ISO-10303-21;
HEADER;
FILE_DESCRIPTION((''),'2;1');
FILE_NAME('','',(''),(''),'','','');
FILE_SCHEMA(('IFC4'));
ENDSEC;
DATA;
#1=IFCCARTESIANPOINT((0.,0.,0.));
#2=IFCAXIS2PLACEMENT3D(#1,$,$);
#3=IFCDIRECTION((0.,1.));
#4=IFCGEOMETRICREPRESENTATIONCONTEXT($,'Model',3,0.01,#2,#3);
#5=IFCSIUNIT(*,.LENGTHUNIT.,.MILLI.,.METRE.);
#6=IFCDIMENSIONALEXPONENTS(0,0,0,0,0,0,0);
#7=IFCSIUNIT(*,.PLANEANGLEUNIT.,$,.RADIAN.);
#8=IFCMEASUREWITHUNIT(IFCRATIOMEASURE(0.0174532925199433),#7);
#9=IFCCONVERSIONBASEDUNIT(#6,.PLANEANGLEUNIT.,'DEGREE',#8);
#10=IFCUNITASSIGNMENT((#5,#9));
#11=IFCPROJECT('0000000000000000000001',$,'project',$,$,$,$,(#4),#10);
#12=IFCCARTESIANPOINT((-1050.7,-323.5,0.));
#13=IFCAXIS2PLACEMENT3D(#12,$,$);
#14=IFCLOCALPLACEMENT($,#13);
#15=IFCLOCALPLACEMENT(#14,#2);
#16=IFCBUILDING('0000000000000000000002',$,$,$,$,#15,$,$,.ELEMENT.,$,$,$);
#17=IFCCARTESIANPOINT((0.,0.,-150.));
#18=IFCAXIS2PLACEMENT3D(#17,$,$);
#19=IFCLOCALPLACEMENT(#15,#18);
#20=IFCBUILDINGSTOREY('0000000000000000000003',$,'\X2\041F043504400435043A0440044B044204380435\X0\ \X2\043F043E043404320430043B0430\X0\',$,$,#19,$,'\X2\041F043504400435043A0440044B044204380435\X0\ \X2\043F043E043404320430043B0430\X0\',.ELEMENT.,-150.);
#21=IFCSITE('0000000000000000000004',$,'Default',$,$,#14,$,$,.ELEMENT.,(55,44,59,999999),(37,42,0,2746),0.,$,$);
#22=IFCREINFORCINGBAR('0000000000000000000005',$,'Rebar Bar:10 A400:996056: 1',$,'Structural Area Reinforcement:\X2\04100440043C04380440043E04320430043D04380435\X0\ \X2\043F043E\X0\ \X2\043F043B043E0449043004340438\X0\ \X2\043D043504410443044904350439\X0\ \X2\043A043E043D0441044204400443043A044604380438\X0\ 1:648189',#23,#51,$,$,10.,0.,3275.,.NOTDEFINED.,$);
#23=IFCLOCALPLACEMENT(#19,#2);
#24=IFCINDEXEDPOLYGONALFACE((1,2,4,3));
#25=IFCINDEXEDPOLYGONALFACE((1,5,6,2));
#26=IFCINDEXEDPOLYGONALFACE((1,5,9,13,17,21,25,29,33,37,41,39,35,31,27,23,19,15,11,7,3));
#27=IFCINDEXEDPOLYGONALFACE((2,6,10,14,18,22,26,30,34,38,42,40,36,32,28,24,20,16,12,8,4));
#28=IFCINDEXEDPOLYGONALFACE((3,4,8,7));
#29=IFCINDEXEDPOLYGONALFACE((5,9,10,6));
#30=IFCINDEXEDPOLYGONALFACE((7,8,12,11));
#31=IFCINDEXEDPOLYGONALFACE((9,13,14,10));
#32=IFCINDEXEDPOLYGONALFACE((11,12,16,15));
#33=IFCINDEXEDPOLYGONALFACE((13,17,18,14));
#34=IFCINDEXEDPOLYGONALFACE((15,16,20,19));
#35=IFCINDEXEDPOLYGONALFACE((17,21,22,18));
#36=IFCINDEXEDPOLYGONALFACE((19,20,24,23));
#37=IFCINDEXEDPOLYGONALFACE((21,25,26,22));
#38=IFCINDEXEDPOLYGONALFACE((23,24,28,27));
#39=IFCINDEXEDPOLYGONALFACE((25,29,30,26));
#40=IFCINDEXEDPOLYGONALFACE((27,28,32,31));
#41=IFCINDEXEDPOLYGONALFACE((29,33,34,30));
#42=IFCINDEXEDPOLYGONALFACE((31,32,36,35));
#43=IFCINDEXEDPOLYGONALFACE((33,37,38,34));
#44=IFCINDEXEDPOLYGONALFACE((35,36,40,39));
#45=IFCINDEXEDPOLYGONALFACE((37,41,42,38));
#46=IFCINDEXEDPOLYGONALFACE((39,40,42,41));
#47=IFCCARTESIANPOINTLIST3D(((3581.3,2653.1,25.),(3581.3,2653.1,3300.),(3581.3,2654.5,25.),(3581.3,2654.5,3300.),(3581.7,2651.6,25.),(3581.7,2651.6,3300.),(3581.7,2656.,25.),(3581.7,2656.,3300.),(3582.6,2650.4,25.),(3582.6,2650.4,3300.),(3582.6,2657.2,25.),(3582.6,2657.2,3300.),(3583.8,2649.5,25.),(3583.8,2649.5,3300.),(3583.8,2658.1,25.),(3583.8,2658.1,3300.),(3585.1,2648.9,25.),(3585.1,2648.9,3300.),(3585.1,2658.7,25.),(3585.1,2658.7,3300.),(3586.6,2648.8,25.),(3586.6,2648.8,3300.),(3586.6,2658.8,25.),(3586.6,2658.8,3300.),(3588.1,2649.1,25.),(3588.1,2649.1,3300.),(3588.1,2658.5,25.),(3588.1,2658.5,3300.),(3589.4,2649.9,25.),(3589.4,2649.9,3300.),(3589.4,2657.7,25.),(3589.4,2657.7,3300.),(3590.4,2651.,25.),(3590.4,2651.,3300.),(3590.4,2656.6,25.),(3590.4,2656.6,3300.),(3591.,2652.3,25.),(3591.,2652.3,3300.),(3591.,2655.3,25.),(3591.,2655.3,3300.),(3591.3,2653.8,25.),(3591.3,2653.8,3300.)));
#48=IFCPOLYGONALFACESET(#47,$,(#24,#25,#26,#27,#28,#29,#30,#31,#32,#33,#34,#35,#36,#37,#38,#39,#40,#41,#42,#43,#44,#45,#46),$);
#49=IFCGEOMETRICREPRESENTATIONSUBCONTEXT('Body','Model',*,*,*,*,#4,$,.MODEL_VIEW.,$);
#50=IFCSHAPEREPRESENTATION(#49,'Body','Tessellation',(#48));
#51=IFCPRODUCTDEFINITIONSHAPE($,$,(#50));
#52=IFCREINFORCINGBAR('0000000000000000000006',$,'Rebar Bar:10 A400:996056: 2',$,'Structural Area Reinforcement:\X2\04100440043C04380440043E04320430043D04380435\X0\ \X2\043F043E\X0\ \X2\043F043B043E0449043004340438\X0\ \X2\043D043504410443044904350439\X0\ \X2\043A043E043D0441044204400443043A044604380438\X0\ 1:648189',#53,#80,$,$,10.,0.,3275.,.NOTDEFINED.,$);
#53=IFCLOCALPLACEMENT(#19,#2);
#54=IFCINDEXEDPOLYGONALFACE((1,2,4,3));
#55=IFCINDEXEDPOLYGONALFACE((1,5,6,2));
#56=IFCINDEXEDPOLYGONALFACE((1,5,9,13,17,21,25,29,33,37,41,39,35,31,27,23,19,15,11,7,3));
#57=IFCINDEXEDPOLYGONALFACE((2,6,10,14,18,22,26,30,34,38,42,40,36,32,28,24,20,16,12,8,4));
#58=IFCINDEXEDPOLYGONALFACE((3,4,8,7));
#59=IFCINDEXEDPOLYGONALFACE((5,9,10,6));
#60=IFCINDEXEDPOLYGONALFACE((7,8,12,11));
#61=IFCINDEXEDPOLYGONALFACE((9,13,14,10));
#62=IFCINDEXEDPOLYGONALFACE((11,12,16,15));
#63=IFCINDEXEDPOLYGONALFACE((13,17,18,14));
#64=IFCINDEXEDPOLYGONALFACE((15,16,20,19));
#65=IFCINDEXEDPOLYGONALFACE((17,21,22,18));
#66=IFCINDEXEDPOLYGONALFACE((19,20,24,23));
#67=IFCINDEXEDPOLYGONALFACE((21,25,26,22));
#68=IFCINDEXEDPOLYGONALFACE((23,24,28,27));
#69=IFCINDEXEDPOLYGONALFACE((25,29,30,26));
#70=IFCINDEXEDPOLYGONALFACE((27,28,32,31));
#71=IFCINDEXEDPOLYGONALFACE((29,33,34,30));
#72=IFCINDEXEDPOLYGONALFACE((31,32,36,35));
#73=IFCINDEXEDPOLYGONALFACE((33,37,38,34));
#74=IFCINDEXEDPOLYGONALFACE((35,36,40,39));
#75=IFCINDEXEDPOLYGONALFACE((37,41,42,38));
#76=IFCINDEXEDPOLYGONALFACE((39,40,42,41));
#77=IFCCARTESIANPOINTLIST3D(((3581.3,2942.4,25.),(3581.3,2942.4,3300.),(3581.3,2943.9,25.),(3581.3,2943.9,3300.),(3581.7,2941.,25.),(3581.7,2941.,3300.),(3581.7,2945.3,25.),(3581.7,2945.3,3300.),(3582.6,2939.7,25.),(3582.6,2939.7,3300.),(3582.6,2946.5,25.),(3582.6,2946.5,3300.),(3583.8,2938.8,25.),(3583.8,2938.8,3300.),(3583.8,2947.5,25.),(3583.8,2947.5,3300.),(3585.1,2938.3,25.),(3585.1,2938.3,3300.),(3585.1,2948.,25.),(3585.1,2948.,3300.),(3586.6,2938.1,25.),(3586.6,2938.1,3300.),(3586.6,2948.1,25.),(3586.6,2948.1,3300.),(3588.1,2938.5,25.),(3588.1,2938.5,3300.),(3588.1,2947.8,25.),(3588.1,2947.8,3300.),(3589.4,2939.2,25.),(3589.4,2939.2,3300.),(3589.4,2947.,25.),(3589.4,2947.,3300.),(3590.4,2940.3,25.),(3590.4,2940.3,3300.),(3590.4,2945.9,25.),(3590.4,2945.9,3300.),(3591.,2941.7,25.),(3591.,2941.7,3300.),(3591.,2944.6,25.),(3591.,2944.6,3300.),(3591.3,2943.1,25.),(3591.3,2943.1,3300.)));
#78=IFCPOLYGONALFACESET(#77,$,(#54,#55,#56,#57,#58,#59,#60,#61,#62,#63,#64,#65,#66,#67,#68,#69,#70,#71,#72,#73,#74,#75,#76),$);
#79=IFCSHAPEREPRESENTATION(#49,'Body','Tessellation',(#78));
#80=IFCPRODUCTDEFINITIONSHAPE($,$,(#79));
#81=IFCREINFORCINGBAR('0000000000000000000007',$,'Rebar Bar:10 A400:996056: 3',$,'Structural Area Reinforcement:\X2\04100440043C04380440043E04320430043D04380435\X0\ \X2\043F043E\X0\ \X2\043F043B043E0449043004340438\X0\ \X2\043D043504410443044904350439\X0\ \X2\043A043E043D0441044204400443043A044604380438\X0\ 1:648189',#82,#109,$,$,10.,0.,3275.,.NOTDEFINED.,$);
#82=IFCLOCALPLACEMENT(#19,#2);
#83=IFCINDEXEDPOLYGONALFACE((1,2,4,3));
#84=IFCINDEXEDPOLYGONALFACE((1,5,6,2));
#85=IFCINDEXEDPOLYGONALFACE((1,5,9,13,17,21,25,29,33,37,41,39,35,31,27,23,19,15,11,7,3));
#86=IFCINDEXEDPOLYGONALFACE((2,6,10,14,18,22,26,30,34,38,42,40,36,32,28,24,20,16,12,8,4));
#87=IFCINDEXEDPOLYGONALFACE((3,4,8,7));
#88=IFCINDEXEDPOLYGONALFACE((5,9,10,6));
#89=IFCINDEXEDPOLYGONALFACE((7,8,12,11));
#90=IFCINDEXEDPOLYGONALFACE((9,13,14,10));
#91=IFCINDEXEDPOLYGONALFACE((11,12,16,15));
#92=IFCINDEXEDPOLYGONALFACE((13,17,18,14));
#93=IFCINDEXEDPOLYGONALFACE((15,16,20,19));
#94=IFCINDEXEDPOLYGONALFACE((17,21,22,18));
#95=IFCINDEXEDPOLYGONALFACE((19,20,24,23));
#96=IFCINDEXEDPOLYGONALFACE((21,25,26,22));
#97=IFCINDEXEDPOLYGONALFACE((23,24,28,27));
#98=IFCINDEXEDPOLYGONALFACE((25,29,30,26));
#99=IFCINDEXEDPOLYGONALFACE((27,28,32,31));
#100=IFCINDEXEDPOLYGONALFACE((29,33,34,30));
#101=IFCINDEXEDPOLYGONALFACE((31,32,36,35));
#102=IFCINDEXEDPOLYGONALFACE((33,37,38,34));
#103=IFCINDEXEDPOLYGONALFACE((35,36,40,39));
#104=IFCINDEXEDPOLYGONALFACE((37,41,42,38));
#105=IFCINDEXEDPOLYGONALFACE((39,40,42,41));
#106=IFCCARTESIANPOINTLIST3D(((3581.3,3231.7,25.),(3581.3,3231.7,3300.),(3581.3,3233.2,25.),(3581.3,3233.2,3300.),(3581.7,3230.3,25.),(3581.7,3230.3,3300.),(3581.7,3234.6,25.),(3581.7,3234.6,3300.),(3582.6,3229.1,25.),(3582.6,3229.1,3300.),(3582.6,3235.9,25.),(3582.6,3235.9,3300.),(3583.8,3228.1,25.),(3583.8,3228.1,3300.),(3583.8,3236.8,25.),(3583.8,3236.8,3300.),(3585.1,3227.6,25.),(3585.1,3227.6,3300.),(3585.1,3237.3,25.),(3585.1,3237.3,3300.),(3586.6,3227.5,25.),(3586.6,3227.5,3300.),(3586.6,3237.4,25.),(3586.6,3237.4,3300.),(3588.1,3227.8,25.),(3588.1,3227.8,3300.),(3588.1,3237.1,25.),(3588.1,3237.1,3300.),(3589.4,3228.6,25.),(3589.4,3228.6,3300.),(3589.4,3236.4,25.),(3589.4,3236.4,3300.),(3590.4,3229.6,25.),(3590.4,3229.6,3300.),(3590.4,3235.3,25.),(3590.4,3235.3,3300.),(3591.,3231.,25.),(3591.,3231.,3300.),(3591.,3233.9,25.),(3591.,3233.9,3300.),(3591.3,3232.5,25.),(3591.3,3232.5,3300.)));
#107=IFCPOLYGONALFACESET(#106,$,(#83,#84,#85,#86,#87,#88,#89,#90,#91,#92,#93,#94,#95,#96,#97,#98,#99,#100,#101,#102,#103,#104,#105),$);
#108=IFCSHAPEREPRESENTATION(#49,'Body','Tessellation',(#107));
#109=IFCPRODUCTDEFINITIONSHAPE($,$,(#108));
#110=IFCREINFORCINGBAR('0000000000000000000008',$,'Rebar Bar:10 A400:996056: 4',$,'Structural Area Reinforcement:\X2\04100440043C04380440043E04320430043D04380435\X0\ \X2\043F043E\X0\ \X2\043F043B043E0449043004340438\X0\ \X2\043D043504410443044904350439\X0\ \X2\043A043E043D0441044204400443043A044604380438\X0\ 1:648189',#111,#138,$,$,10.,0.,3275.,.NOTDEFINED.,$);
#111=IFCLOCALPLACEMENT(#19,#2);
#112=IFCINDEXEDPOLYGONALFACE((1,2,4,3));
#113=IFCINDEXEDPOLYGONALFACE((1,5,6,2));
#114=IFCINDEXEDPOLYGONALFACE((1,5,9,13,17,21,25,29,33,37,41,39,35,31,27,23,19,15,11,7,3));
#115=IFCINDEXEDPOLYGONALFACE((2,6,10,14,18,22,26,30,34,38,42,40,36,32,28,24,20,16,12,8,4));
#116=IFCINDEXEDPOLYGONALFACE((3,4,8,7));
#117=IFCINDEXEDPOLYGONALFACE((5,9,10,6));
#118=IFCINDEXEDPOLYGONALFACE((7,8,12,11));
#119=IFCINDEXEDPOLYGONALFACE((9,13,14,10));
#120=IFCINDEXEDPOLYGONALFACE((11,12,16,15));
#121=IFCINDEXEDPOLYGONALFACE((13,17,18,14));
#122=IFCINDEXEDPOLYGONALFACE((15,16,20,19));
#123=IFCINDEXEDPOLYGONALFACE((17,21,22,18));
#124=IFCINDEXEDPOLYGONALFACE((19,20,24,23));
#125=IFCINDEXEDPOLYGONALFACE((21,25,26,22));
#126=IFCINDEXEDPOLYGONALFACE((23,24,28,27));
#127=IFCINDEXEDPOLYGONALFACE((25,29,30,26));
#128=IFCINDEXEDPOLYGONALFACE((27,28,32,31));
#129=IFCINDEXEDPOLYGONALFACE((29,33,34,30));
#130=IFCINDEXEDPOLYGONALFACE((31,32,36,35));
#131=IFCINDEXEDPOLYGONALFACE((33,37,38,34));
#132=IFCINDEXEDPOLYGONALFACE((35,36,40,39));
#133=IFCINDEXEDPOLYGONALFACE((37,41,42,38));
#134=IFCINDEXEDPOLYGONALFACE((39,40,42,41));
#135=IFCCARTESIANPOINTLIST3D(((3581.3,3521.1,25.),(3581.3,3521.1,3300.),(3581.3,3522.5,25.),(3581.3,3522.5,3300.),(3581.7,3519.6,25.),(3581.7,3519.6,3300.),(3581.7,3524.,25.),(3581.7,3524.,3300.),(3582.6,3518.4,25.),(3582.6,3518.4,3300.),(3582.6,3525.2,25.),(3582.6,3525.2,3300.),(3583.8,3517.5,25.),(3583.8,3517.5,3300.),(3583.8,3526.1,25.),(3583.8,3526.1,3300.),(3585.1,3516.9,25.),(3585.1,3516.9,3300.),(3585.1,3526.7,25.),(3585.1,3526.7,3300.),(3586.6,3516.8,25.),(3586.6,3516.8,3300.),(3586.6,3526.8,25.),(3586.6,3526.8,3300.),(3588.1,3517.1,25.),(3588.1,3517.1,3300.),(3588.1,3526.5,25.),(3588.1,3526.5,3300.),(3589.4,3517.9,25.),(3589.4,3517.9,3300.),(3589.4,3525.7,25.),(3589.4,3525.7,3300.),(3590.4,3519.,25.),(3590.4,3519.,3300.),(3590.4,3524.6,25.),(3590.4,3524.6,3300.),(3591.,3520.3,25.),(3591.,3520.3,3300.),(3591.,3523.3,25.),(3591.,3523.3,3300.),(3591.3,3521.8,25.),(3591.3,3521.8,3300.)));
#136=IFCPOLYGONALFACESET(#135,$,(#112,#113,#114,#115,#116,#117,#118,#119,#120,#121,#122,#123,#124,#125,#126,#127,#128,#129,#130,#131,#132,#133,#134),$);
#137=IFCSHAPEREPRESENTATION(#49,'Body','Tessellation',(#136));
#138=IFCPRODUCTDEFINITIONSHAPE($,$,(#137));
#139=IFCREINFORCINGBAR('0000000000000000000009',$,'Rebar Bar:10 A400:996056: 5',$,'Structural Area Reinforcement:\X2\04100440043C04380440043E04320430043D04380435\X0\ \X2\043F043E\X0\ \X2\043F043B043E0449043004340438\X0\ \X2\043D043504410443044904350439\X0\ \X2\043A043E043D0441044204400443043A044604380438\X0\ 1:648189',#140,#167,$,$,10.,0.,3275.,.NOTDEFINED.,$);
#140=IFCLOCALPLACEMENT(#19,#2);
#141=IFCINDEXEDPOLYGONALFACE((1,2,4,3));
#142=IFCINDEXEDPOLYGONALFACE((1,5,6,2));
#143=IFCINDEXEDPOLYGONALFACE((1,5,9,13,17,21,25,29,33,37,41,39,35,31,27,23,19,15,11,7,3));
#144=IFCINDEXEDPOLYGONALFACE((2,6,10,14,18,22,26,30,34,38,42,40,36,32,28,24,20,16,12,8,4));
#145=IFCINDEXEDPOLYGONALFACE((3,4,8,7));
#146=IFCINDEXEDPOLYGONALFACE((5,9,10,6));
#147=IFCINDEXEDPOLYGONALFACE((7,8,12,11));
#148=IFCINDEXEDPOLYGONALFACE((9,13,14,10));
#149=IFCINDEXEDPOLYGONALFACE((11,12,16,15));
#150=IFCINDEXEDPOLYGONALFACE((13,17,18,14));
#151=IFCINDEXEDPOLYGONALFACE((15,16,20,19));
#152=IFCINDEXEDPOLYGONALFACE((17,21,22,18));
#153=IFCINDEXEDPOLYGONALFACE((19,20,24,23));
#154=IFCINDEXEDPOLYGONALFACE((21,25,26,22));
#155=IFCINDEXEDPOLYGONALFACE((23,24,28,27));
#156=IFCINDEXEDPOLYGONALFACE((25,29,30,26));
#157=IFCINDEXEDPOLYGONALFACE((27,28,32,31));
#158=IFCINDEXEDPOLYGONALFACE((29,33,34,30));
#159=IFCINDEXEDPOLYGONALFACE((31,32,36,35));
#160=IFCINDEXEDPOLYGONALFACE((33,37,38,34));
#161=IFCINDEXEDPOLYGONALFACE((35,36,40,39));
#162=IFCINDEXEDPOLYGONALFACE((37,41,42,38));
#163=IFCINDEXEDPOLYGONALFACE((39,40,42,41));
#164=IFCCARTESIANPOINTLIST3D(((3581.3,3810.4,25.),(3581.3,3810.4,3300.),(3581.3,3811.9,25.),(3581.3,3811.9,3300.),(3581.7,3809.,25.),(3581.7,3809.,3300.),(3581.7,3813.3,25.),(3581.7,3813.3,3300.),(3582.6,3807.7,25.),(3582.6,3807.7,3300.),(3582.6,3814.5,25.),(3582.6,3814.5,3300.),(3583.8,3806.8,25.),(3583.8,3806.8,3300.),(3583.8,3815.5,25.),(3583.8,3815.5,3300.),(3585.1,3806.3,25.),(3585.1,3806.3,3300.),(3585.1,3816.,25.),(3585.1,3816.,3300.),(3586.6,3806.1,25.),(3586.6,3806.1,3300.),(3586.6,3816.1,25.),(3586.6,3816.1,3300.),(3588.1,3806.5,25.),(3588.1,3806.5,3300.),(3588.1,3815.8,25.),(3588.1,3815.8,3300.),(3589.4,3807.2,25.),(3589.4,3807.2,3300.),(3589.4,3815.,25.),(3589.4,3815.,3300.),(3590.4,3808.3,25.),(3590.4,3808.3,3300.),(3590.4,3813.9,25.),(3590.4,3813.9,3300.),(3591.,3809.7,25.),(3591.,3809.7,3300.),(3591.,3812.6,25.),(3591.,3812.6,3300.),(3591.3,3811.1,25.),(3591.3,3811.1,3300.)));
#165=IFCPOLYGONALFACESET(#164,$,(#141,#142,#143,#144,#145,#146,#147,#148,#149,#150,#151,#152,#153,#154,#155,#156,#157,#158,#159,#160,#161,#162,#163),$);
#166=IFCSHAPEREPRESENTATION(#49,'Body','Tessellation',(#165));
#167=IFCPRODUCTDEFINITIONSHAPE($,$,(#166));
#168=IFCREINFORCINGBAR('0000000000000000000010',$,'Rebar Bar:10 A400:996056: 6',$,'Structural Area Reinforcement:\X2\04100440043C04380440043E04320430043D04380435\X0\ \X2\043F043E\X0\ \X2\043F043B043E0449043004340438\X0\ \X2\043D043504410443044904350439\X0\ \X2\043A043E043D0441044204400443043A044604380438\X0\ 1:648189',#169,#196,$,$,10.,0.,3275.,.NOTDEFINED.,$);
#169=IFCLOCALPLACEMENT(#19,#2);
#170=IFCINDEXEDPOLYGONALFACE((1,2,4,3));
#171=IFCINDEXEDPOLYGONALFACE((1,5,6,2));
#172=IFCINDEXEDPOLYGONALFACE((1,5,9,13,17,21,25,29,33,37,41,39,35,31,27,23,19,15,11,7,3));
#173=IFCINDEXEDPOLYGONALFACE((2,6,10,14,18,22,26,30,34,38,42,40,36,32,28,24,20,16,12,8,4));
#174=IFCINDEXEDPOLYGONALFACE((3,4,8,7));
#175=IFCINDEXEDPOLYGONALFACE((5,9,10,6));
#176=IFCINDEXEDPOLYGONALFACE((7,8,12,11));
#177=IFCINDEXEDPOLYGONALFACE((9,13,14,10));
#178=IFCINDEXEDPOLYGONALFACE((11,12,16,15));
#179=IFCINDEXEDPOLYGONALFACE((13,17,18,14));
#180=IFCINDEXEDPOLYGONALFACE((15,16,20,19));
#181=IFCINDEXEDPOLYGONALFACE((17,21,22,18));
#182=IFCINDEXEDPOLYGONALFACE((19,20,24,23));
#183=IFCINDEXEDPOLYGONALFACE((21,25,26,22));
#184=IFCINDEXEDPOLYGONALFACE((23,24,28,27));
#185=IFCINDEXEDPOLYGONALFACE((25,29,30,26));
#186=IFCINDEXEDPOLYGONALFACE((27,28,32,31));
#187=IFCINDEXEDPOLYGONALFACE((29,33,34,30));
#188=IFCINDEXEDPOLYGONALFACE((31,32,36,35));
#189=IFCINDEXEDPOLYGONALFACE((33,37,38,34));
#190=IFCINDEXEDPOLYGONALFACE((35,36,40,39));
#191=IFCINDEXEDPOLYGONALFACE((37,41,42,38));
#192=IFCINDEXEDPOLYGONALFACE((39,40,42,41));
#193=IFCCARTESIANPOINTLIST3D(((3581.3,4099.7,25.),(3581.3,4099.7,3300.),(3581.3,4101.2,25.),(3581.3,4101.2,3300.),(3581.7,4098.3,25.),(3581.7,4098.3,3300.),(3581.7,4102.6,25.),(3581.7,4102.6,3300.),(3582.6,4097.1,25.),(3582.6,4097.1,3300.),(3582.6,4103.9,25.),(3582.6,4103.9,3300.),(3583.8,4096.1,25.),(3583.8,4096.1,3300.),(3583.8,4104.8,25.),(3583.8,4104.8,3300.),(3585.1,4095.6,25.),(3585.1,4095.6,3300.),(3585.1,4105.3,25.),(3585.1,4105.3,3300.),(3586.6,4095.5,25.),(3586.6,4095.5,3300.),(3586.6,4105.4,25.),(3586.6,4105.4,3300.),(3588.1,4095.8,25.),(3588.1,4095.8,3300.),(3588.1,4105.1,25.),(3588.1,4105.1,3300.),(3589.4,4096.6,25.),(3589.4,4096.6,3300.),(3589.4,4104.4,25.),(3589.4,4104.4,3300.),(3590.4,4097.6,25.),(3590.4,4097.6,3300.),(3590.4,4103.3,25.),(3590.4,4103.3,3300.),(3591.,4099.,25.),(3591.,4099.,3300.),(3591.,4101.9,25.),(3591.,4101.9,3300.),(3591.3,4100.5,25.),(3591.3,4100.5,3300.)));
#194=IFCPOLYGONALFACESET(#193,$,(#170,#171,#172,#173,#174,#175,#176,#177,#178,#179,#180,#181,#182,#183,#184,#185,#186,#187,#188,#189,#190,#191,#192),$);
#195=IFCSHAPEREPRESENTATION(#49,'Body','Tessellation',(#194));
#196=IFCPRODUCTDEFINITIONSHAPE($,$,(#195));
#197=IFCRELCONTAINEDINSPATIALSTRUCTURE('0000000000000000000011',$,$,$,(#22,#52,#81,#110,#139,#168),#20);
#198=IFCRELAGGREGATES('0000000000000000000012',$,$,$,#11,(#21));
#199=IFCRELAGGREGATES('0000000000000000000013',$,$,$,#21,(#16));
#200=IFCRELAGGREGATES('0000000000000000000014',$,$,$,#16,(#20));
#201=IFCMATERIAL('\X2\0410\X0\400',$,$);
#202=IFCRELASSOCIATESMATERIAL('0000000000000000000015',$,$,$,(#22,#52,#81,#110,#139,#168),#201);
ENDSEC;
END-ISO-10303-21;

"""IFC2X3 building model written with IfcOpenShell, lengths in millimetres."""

from ifc_helpers import new_model, entity, si_unit, converted_unit, direction, frame, origin, place, context, subcontext, project, spatial, material, element, save


model = new_model("IFC2X3")

# Units and contexts
model_context = context("Model", 3, precision=0.01, world=origin(), true_north=direction((0.0, 1.0)))
body_context = subcontext(model_context, "Body", "Model", "MODEL_VIEW")
ifc_project = project(units=[si_unit("LENGTHUNIT", "METRE", prefix="MILLI"), converted_unit("PLANEANGLEUNIT", "DEGREE", entity("IfcRatioMeasure", 0.0174532925199433), si_unit("PLANEANGLEUNIT", "RADIAN"), dimensions=[0, 0, 0, 0, 0, 0, 0])], contexts=[model_context])

# Site, building, storey
site_placement = place(None, frame((-1050.7, -323.5, 0.0)))
site = spatial("IfcSite", under=ifc_project, at=site_placement, Name="Default", CompositionType="ELEMENT", RefLatitude=(55, 44, 59, 999999), RefLongitude=(37, 42, 0, 2746), RefElevation=0.0)
building_placement = place(site_placement, origin())
building = spatial("IfcBuilding", under=site, at=building_placement, CompositionType="ELEMENT")
storey_placement = place(building_placement, frame((0.0, 0.0, -150.0)))
storey = spatial("IfcBuildingStorey", under=building, at=storey_placement, Name="Перекрытие подвала", LongName="Перекрытие подвала", CompositionType="ELEMENT", Elevation=-150.0)

# Reinforcing bars
ifc_material = material(Name="А400")
reinforcing_bar_1_placement = place(storey_placement, origin())
element("IfcReinforcingBar", 1, at=reinforcing_bar_1_placement, inside=storey, material=ifc_material, Name="Rebar Bar:10 A400:996056: 1", ObjectType="Structural Area Reinforcement:Армирование по площади несущей конструкции 1:648189", BarLength=3275.0, BarRole="NOTDEFINED", CrossSectionArea=0.0, NominalDiameter=10.0, context=body_context, shape_type="AdvancedSweptSolid", body=[
    entity("IfcSweptDiskSolid", entity("IfcCompositeCurve", [entity("IfcCompositeCurveSegment", "CONTINUOUS", True, entity("IfcPolyline", [entity("IfcCartesianPoint", [3586.3, 2653.8, 25.0]), entity("IfcCartesianPoint", [3586.3, 2653.8, 3300.0])]))], False), 5.0, None, 0.0, 1.0),
])
reinforcing_bar_2_placement = place(storey_placement, origin())
element("IfcReinforcingBar", 2, at=reinforcing_bar_2_placement, inside=storey, material=ifc_material, Name="Rebar Bar:10 A400:996056: 2", ObjectType="Structural Area Reinforcement:Армирование по площади несущей конструкции 1:648189", BarLength=3275.0, BarRole="NOTDEFINED", CrossSectionArea=0.0, NominalDiameter=10.0, context=body_context, shape_type="AdvancedSweptSolid", body=[
    entity("IfcSweptDiskSolid", entity("IfcCompositeCurve", [entity("IfcCompositeCurveSegment", "CONTINUOUS", True, entity("IfcPolyline", [entity("IfcCartesianPoint", [3586.3, 2943.1, 25.0]), entity("IfcCartesianPoint", [3586.3, 2943.1, 3300.0])]))], False), 5.0, None, 0.0, 1.0),
])
reinforcing_bar_3_placement = place(storey_placement, origin())
element("IfcReinforcingBar", 3, at=reinforcing_bar_3_placement, inside=storey, material=ifc_material, Name="Rebar Bar:10 A400:996056: 3", ObjectType="Structural Area Reinforcement:Армирование по площади несущей конструкции 1:648189", BarLength=3275.0, BarRole="NOTDEFINED", CrossSectionArea=0.0, NominalDiameter=10.0, context=body_context, shape_type="AdvancedSweptSolid", body=[
    entity("IfcSweptDiskSolid", entity("IfcCompositeCurve", [entity("IfcCompositeCurveSegment", "CONTINUOUS", True, entity("IfcPolyline", [entity("IfcCartesianPoint", [3586.3, 3232.5, 25.0]), entity("IfcCartesianPoint", [3586.3, 3232.5, 3300.0])]))], False), 5.0, None, 0.0, 1.0),
])
reinforcing_bar_4_placement = place(storey_placement, origin())
element("IfcReinforcingBar", 4, at=reinforcing_bar_4_placement, inside=storey, material=ifc_material, Name="Rebar Bar:10 A400:996056: 4", ObjectType="Structural Area Reinforcement:Армирование по площади несущей конструкции 1:648189", BarLength=3275.0, BarRole="NOTDEFINED", CrossSectionArea=0.0, NominalDiameter=10.0, context=body_context, shape_type="AdvancedSweptSolid", body=[
    entity("IfcSweptDiskSolid", entity("IfcCompositeCurve", [entity("IfcCompositeCurveSegment", "CONTINUOUS", True, entity("IfcPolyline", [entity("IfcCartesianPoint", [3586.3, 3521.8, 25.0]), entity("IfcCartesianPoint", [3586.3, 3521.8, 3300.0])]))], False), 5.0, None, 0.0, 1.0),
])
reinforcing_bar_5_placement = place(storey_placement, origin())
element("IfcReinforcingBar", 5, at=reinforcing_bar_5_placement, inside=storey, material=ifc_material, Name="Rebar Bar:10 A400:996056: 5", ObjectType="Structural Area Reinforcement:Армирование по площади несущей конструкции 1:648189", BarLength=3275.0, BarRole="NOTDEFINED", CrossSectionArea=0.0, NominalDiameter=10.0, context=body_context, shape_type="AdvancedSweptSolid", body=[
    entity("IfcSweptDiskSolid", entity("IfcCompositeCurve", [entity("IfcCompositeCurveSegment", "CONTINUOUS", True, entity("IfcPolyline", [entity("IfcCartesianPoint", [3586.3, 3811.1, 25.0]), entity("IfcCartesianPoint", [3586.3, 3811.1, 3300.0])]))], False), 5.0, None, 0.0, 1.0),
])
reinforcing_bar_6_placement = place(storey_placement, origin())
element("IfcReinforcingBar", 6, at=reinforcing_bar_6_placement, inside=storey, material=ifc_material, Name="Rebar Bar:10 A400:996056: 6", ObjectType="Structural Area Reinforcement:Армирование по площади несущей конструкции 1:648189", BarLength=3275.0, BarRole="NOTDEFINED", CrossSectionArea=0.0, NominalDiameter=10.0, context=body_context, shape_type="AdvancedSweptSolid", body=[
    entity("IfcSweptDiskSolid", entity("IfcCompositeCurve", [entity("IfcCompositeCurveSegment", "CONTINUOUS", True, entity("IfcPolyline", [entity("IfcCartesianPoint", [3586.3, 4100.5, 25.0]), entity("IfcCartesianPoint", [3586.3, 4100.5, 3300.0])]))], False), 5.0, None, 0.0, 1.0),
])

save(model, "model.ifc")
